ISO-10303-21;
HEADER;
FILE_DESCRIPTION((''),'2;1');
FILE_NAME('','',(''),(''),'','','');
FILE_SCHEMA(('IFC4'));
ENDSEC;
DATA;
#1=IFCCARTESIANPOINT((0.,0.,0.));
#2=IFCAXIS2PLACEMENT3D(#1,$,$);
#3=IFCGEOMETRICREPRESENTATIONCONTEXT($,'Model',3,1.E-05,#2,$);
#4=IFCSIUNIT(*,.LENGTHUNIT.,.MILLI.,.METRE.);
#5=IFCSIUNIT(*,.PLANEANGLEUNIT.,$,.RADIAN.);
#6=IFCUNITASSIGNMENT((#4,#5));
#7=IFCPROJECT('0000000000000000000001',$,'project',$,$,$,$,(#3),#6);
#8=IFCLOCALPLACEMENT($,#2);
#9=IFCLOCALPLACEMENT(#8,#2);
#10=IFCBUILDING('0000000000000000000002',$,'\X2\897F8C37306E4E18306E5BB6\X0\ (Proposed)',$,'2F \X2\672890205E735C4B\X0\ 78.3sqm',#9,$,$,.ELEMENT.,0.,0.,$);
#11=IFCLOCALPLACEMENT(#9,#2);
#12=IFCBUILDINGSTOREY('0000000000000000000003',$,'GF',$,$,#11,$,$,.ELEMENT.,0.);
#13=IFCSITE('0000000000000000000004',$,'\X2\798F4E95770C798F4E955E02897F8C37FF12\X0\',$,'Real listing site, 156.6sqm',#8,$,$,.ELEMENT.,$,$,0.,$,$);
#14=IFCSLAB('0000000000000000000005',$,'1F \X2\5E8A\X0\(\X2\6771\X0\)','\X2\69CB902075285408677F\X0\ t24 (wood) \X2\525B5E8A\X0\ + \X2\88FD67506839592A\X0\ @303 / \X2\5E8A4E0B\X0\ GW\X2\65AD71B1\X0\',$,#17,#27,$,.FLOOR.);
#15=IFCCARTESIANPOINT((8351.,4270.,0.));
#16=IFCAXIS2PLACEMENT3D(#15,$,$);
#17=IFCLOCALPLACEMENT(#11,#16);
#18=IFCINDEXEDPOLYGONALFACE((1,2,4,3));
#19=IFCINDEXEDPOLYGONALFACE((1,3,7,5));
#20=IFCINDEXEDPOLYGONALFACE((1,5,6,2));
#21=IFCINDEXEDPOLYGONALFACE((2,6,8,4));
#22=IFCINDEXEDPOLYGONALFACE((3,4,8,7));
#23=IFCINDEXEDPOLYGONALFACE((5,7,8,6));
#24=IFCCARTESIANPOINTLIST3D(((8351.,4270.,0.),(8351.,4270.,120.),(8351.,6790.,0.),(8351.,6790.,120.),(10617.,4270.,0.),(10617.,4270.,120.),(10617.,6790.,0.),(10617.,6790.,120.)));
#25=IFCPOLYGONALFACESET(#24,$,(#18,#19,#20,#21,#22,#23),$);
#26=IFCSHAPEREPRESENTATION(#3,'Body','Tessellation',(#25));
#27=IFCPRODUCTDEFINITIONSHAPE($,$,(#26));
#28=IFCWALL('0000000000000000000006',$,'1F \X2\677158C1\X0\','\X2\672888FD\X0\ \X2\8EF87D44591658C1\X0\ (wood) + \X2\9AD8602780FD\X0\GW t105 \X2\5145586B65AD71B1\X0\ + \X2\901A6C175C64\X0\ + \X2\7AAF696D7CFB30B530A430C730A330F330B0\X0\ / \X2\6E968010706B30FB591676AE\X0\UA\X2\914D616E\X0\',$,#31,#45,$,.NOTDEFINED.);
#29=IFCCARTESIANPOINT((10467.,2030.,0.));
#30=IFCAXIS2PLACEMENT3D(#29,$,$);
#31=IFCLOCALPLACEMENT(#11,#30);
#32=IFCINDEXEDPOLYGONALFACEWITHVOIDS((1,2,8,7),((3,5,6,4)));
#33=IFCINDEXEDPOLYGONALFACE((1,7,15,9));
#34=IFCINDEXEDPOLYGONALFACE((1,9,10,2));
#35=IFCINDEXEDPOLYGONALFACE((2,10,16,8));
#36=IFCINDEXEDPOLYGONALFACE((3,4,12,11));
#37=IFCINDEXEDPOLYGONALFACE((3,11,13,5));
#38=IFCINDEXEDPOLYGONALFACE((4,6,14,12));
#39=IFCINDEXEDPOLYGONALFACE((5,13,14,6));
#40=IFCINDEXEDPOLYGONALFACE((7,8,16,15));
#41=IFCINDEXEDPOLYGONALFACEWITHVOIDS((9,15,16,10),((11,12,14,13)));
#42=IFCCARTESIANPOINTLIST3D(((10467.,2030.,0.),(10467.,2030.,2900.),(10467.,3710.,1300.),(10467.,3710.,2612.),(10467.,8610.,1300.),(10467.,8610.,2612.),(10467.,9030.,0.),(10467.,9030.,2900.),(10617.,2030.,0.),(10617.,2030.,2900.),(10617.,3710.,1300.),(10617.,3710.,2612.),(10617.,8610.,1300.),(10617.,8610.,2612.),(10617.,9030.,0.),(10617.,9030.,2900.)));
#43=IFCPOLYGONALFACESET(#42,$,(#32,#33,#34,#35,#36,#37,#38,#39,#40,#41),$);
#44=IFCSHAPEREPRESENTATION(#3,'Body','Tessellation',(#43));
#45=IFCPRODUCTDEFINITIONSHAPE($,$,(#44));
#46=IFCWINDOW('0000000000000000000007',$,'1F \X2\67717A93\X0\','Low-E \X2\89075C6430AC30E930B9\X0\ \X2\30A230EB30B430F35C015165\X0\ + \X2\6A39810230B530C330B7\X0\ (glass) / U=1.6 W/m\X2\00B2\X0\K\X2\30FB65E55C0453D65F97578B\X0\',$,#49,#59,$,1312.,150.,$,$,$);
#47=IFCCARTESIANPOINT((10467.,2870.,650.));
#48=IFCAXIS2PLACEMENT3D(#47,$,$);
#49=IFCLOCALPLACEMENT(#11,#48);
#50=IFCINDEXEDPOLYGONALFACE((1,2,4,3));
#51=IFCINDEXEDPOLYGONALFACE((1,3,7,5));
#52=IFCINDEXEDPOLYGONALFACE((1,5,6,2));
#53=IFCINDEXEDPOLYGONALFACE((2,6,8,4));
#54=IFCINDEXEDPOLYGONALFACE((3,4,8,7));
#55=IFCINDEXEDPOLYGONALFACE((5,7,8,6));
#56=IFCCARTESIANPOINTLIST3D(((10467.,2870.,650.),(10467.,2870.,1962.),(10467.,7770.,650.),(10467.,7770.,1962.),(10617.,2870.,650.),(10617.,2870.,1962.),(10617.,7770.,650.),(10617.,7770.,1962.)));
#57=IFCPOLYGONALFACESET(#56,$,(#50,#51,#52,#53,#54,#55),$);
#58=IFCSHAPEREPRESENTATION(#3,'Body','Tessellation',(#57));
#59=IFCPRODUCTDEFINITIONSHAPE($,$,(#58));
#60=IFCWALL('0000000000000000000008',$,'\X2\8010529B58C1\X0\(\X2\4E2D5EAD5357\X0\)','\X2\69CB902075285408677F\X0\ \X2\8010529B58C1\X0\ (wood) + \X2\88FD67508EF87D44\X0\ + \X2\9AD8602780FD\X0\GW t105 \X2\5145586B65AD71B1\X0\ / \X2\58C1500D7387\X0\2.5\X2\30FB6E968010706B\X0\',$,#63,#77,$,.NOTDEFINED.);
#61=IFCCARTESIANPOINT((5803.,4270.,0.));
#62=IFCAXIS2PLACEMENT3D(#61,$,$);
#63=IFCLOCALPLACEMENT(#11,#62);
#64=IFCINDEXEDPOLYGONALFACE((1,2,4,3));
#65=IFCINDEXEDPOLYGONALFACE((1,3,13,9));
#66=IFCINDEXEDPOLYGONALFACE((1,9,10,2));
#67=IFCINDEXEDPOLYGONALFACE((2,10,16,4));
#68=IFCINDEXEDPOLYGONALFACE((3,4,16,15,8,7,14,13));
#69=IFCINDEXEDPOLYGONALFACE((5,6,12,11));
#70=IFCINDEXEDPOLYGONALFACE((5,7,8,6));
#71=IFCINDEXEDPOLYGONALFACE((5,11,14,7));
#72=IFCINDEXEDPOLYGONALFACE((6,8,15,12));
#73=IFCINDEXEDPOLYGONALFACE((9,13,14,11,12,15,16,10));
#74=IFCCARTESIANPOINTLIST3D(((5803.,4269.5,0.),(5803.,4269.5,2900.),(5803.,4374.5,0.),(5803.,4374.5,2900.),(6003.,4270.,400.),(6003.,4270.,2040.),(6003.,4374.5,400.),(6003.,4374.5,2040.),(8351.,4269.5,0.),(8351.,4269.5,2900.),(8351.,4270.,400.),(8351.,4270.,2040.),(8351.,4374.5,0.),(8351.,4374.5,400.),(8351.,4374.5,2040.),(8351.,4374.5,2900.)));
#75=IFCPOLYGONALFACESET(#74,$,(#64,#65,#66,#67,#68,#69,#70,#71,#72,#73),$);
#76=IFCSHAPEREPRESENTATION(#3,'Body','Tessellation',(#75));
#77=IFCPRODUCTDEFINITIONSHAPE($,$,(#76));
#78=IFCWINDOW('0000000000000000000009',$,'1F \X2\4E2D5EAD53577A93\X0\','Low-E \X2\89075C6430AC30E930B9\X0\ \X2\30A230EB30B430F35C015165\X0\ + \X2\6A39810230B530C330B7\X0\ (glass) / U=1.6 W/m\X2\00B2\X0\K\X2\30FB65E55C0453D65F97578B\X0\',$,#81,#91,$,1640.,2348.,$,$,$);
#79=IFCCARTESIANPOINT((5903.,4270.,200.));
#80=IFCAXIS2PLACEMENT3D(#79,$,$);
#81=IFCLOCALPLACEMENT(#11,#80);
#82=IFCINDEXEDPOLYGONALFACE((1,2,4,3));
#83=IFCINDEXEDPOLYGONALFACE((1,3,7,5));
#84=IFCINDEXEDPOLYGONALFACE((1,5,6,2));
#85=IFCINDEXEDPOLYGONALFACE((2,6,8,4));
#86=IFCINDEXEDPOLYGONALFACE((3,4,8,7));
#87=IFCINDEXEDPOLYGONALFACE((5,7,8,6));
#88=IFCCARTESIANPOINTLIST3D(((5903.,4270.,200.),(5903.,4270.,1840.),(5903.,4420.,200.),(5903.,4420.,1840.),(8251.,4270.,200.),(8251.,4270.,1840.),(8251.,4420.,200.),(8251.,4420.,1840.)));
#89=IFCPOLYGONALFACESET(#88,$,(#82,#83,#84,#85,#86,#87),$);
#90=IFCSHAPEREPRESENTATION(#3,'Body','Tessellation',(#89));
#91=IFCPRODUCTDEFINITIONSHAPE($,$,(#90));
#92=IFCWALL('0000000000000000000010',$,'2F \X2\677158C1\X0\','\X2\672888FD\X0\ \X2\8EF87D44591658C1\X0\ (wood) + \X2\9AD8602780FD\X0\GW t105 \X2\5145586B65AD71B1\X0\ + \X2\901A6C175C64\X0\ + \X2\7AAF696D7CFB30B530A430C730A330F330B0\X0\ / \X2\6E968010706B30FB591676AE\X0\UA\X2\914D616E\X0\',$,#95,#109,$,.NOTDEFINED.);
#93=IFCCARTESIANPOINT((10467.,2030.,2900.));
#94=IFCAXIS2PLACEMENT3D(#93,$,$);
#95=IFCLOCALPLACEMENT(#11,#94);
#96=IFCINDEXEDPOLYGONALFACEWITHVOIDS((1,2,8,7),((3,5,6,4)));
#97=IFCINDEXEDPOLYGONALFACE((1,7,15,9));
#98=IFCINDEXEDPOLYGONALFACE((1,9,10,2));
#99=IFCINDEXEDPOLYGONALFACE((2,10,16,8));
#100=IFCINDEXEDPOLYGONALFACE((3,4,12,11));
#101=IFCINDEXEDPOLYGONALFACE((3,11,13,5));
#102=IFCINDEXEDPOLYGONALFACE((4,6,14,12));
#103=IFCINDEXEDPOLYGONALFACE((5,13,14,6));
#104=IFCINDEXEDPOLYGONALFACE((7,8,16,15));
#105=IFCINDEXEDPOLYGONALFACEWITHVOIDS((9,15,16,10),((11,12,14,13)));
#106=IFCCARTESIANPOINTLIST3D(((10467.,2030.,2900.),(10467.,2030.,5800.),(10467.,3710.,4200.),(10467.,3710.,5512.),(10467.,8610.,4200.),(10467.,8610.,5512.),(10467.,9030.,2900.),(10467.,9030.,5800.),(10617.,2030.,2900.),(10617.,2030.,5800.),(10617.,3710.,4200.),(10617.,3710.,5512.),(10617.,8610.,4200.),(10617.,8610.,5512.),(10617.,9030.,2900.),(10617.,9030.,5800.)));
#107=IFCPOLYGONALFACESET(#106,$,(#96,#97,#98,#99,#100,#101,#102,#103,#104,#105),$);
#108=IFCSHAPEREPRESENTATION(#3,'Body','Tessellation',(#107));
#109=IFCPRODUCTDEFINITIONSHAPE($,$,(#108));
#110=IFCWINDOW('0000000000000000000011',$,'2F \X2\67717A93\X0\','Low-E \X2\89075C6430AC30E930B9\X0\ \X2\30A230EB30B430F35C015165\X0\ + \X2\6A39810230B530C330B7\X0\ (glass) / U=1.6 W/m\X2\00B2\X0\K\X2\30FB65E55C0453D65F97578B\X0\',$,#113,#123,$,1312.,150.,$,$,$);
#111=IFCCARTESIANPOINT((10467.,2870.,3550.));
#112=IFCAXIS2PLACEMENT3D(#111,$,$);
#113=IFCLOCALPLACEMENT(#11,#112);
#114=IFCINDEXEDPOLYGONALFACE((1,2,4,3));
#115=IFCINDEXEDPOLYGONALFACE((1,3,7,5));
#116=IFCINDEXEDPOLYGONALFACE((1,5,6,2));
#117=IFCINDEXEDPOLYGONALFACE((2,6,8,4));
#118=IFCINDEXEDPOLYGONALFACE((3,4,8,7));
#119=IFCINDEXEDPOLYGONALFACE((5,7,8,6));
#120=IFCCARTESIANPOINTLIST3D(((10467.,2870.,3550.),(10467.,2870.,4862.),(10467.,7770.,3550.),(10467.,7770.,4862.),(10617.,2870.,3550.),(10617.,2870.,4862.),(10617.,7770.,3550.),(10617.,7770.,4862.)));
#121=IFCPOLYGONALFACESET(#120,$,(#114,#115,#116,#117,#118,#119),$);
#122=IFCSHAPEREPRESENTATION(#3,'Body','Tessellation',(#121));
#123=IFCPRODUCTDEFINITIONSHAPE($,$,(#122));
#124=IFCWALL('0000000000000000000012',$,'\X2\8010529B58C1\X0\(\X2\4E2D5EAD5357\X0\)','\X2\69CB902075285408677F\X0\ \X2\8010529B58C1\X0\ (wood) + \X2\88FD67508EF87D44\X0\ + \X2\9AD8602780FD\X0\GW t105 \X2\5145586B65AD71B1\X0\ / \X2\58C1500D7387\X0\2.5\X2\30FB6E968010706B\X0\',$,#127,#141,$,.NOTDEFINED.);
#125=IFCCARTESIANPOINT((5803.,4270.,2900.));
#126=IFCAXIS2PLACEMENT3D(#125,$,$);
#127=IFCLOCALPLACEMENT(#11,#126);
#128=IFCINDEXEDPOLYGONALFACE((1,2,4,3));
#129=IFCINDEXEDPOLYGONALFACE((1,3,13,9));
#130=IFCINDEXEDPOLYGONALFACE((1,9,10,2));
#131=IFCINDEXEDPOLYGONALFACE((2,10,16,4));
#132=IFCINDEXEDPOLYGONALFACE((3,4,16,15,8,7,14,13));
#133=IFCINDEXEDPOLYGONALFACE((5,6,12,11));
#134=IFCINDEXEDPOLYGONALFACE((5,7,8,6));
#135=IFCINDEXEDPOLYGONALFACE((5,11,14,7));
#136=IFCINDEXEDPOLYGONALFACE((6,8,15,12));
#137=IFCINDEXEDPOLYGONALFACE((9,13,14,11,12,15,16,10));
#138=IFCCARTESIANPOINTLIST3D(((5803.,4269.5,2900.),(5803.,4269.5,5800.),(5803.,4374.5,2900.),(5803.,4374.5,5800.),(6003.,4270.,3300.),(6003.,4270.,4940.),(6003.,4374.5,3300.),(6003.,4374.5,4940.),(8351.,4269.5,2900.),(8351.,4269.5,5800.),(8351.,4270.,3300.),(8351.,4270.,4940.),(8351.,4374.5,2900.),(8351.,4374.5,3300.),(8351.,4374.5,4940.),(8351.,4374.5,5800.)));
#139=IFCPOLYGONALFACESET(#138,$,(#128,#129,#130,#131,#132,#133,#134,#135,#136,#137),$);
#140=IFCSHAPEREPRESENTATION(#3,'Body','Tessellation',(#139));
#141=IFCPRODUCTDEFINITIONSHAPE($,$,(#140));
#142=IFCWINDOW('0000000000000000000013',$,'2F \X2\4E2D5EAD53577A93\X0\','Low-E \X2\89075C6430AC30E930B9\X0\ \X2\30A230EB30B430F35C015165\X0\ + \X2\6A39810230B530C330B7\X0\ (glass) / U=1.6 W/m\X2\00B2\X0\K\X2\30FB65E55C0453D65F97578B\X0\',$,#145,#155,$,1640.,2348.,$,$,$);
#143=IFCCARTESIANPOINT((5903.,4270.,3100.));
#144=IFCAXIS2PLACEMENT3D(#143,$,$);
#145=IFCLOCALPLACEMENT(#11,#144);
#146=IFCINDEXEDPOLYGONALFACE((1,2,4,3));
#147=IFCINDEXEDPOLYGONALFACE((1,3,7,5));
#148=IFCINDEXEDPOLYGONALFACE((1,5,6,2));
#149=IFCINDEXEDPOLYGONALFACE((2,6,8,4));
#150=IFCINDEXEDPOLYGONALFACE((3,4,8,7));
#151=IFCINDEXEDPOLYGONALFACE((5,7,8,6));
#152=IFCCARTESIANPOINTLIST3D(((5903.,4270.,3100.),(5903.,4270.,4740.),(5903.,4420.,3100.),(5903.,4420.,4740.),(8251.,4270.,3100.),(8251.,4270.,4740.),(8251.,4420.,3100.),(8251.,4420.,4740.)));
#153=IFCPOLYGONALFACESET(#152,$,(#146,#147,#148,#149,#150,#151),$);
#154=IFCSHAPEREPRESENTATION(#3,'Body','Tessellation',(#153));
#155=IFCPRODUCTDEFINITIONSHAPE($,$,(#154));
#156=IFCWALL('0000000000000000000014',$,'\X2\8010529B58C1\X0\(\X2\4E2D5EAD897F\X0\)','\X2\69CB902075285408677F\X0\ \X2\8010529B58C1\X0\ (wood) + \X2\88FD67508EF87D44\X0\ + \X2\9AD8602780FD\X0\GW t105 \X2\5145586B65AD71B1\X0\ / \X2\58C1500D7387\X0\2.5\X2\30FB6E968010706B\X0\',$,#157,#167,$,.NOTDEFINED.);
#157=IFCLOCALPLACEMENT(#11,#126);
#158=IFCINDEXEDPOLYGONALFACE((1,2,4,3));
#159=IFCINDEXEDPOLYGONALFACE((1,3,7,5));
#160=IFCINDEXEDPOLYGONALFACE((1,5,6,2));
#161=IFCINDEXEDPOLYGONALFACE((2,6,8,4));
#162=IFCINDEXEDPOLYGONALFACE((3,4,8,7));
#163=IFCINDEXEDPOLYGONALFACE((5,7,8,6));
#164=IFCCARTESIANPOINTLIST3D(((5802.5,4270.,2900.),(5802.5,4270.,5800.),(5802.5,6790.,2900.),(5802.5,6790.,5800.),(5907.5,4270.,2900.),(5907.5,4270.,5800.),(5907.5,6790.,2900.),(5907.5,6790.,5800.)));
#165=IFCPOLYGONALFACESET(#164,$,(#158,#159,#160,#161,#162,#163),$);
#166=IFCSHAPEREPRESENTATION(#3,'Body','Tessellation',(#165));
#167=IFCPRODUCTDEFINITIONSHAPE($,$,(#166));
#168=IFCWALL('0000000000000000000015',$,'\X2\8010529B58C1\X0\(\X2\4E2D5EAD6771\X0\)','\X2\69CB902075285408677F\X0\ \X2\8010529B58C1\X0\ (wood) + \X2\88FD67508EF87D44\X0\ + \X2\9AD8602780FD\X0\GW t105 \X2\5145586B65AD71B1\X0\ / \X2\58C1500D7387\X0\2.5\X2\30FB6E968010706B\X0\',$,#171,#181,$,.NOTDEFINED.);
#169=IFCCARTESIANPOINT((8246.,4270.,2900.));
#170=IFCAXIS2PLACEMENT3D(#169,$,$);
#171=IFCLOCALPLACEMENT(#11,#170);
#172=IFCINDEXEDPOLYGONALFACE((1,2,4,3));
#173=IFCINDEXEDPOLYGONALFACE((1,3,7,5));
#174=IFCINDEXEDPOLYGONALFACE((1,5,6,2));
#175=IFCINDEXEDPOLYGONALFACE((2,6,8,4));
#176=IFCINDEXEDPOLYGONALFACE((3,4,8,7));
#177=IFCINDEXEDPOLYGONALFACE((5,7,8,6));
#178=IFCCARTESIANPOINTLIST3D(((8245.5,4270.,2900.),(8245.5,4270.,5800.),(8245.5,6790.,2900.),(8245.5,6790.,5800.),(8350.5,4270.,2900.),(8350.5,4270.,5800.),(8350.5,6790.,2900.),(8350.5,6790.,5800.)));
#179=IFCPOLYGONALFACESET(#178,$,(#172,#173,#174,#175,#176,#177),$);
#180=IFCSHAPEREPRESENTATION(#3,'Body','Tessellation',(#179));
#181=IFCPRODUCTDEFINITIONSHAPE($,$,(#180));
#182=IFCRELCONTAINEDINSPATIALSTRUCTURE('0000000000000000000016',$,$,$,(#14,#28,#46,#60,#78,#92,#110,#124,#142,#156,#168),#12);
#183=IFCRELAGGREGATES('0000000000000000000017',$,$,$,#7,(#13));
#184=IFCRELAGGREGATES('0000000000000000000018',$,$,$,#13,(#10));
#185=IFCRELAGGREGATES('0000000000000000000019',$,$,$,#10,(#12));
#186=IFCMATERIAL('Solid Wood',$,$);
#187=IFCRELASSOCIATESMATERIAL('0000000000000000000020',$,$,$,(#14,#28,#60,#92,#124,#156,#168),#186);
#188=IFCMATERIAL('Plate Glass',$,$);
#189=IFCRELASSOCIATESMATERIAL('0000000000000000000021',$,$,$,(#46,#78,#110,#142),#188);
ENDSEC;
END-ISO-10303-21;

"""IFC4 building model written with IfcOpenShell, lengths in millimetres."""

from ifc_helpers import new_model, si_unit, frame, frame_2d, origin, place, context, project, spatial, rectangle, extrude, material, element, fill, save


model = new_model("IFC4")

# Units and contexts
model_context = context("Model", 3, precision=1e-05, world=origin())
ifc_project = project(units=[si_unit("LENGTHUNIT", "METRE", prefix="MILLI"), si_unit("PLANEANGLEUNIT", "RADIAN")], contexts=[model_context])

# Site, building, storey
site_placement = place(None, origin())
site = spatial("IfcSite", under=ifc_project, at=site_placement, Name="福井県福井市西谷２", ObjectType="Real listing site, 156.6sqm", CompositionType="ELEMENT", RefElevation=0.0)
building_placement = place(site_placement, origin())
building = spatial("IfcBuilding", under=site, at=building_placement, Name="西谷の丘の家 (Proposed)", ObjectType="2F 木造平屋 78.3sqm", CompositionType="ELEMENT", ElevationOfRefHeight=0.0, ElevationOfTerrain=0.0)
storey_placement = place(building_placement, origin())
storey = spatial("IfcBuildingStorey", under=building, at=storey_placement, Name="GF", CompositionType="ELEMENT", Elevation=0.0)

# Slab
ifc_material_1 = material(Name="Solid Wood")
slab_placement = place(storey_placement, frame((8351.0, 4270.0, 0.0)))
element("IfcSlab", 1, at=slab_placement, inside=storey, material=ifc_material_1, Name="1F 床(東)", Description="構造用合板 t24 (wood) 剛床 + 製材根太 @303 / 床下 GW断熱", PredefinedType="FLOOR", context=model_context, shape_type="SweptSolid", body=[
    extrude(rectangle(XDim=2266.0, YDim=2520.0, at=frame_2d((1133.0, 1260.0))), frame((8351.0, 4270.0, 0.0)), (0.0, 0.0, 1.0), 120.0),
])

# Walls, openings, windows
wall_1_placement = place(storey_placement, frame((10467.0, 2030.0, 0.0)))
wall_1 = element("IfcWall", 2, at=wall_1_placement, inside=storey, material=ifc_material_1, Name="1F 東壁", Description="木製 軸組外壁 (wood) + 高性能GW t105 充填断熱 + 通気層 + 窯業系サイディング / 準耐火・外皮UA配慮", PredefinedType="NOTDEFINED", context=model_context, shape_type="SweptSolid", body=[
    extrude(rectangle(XDim=150.0, YDim=7000.0, at=frame_2d((75.0, 3500.0))), frame((10467.0, 2030.0, 0.0)), (0.0, 0.0, 1.0), 2900.0),
])
opening_1_placement = place(storey_placement, frame((10467.0, 2870.0, 650.0)))
opening_1 = element("IfcOpeningElement", 3, at=opening_1_placement, cuts=wall_1, PredefinedType="NOTDEFINED", context=model_context, shape_type="SweptSolid", body=[
    extrude(rectangle(XDim=150.0, YDim=4900.0, at=frame_2d((75.0, 2450.0))), frame((10467.0, 2870.0, 650.0)), (0.0, 0.0, 1.0), 1312.0),
])
ifc_material_2 = material(Name="Plate Glass")
window_1_placement = place(storey_placement, frame((10467.0, 2870.0, 650.0)))
window_1 = element("IfcWindow", 4, at=window_1_placement, inside=storey, material=ifc_material_2, Name="1F 東窓", Description="Low-E 複層ガラス アルゴン封入 + 樹脂サッシ (glass) / U=1.6 W/m²K・日射取得型", OverallHeight=1312.0, OverallWidth=150.0, context=model_context, shape_type="SweptSolid", body=[
    extrude(rectangle(XDim=150.0, YDim=4900.0, at=frame_2d((75.0, 2450.0))), frame((10467.0, 2870.0, 650.0)), (0.0, 0.0, 1.0), 1312.0),
])
fill(opening_1, window_1)
wall_2_placement = place(storey_placement, frame((5803.0, 4270.0, 0.0)))
wall_2 = element("IfcWall", 5, at=wall_2_placement, inside=storey, material=ifc_material_1, Name="耐力壁(中庭南)", Description="構造用合板 耐力壁 (wood) + 製材軸組 + 高性能GW t105 充填断熱 / 壁倍率2.5・準耐火", PredefinedType="NOTDEFINED", context=model_context, shape_type="SweptSolid", body=[
    extrude(rectangle(XDim=2548.0, YDim=105.0, at=frame_2d((1274.0, 52.0))), frame((5803.0, 4270.0, 0.0)), (0.0, 0.0, 1.0), 2900.0),
])
opening_2_placement = place(storey_placement, frame((5903.0, 4270.0, 200.0)))
opening_2 = element("IfcOpeningElement", 6, at=opening_2_placement, cuts=wall_2, PredefinedType="NOTDEFINED", context=model_context, shape_type="SweptSolid", body=[
    extrude(rectangle(XDim=2348.0, YDim=150.0, at=frame_2d((1174.0, 75.0))), frame((5903.0, 4270.0, 200.0)), (0.0, 0.0, 1.0), 1640.0),
])
window_2_placement = place(storey_placement, frame((5903.0, 4270.0, 200.0)))
window_2 = element("IfcWindow", 7, at=window_2_placement, inside=storey, material=ifc_material_2, Name="1F 中庭南窓", Description="Low-E 複層ガラス アルゴン封入 + 樹脂サッシ (glass) / U=1.6 W/m²K・日射取得型", OverallHeight=1640.0, OverallWidth=2348.0, context=model_context, shape_type="SweptSolid", body=[
    extrude(rectangle(XDim=2348.0, YDim=150.0, at=frame_2d((1174.0, 75.0))), frame((5903.0, 4270.0, 200.0)), (0.0, 0.0, 1.0), 1640.0),
])
fill(opening_2, window_2)

# Walls, openings, windows
wall_3_placement = place(storey_placement, frame((10467.0, 2030.0, 2900.0)))
wall_3 = element("IfcWall", 8, at=wall_3_placement, inside=storey, material=ifc_material_1, Name="2F 東壁", Description="木製 軸組外壁 (wood) + 高性能GW t105 充填断熱 + 通気層 + 窯業系サイディング / 準耐火・外皮UA配慮", PredefinedType="NOTDEFINED", context=model_context, shape_type="SweptSolid", body=[
    extrude(rectangle(XDim=150.0, YDim=7000.0, at=frame_2d((75.0, 3500.0))), frame((10467.0, 2030.0, 2900.0)), (0.0, 0.0, 1.0), 2900.0),
])
opening_3_placement = place(storey_placement, frame((10467.0, 2870.0, 3550.0)))
opening_3 = element("IfcOpeningElement", 9, at=opening_3_placement, cuts=wall_3, PredefinedType="NOTDEFINED", context=model_context, shape_type="SweptSolid", body=[
    extrude(rectangle(XDim=150.0, YDim=4900.0, at=frame_2d((75.0, 2450.0))), frame((10467.0, 2870.0, 3550.0)), (0.0, 0.0, 1.0), 1312.0),
])
window_3_placement = place(storey_placement, frame((10467.0, 2870.0, 3550.0)))
window_3 = element("IfcWindow", 10, at=window_3_placement, inside=storey, material=ifc_material_2, Name="2F 東窓", Description="Low-E 複層ガラス アルゴン封入 + 樹脂サッシ (glass) / U=1.6 W/m²K・日射取得型", OverallHeight=1312.0, OverallWidth=150.0, context=model_context, shape_type="SweptSolid", body=[
    extrude(rectangle(XDim=150.0, YDim=4900.0, at=frame_2d((75.0, 2450.0))), frame((10467.0, 2870.0, 3550.0)), (0.0, 0.0, 1.0), 1312.0),
])
fill(opening_3, window_3)
wall_4_placement = place(storey_placement, frame((5803.0, 4270.0, 2900.0)))
wall_4 = element("IfcWall", 11, at=wall_4_placement, inside=storey, material=ifc_material_1, Name="耐力壁(中庭南)", Description="構造用合板 耐力壁 (wood) + 製材軸組 + 高性能GW t105 充填断熱 / 壁倍率2.5・準耐火", PredefinedType="NOTDEFINED", context=model_context, shape_type="SweptSolid", body=[
    extrude(rectangle(XDim=2548.0, YDim=105.0, at=frame_2d((1274.0, 52.0))), frame((5803.0, 4270.0, 2900.0)), (0.0, 0.0, 1.0), 2900.0),
])
opening_4_placement = place(storey_placement, frame((5903.0, 4270.0, 3100.0)))
opening_4 = element("IfcOpeningElement", 12, at=opening_4_placement, cuts=wall_4, PredefinedType="NOTDEFINED", context=model_context, shape_type="SweptSolid", body=[
    extrude(rectangle(XDim=2348.0, YDim=150.0, at=frame_2d((1174.0, 75.0))), frame((5903.0, 4270.0, 3100.0)), (0.0, 0.0, 1.0), 1640.0),
])
window_4_placement = place(storey_placement, frame((5903.0, 4270.0, 3100.0)))
window_4 = element("IfcWindow", 13, at=window_4_placement, inside=storey, material=ifc_material_2, Name="2F 中庭南窓", Description="Low-E 複層ガラス アルゴン封入 + 樹脂サッシ (glass) / U=1.6 W/m²K・日射取得型", OverallHeight=1640.0, OverallWidth=2348.0, context=model_context, shape_type="SweptSolid", body=[
    extrude(rectangle(XDim=2348.0, YDim=150.0, at=frame_2d((1174.0, 75.0))), frame((5903.0, 4270.0, 3100.0)), (0.0, 0.0, 1.0), 1640.0),
])
fill(opening_4, window_4)

# Walls
wall_5_placement = place(storey_placement, frame((5803.0, 4270.0, 2900.0)))
element("IfcWall", 14, at=wall_5_placement, inside=storey, material=ifc_material_1, Name="耐力壁(中庭西)", Description="構造用合板 耐力壁 (wood) + 製材軸組 + 高性能GW t105 充填断熱 / 壁倍率2.5・準耐火", PredefinedType="NOTDEFINED", context=model_context, shape_type="SweptSolid", body=[
    extrude(rectangle(XDim=105.0, YDim=2520.0, at=frame_2d((52.0, 1260.0))), frame((5803.0, 4270.0, 2900.0)), (0.0, 0.0, 1.0), 2900.0),
])
wall_6_placement = place(storey_placement, frame((8246.0, 4270.0, 2900.0)))
element("IfcWall", 15, at=wall_6_placement, inside=storey, material=ifc_material_1, Name="耐力壁(中庭東)", Description="構造用合板 耐力壁 (wood) + 製材軸組 + 高性能GW t105 充填断熱 / 壁倍率2.5・準耐火", PredefinedType="NOTDEFINED", context=model_context, shape_type="SweptSolid", body=[
    extrude(rectangle(XDim=105.0, YDim=2520.0, at=frame_2d((52.0, 1260.0))), frame((8246.0, 4270.0, 2900.0)), (0.0, 0.0, 1.0), 2900.0),
])

save(model, "model.ifc")
